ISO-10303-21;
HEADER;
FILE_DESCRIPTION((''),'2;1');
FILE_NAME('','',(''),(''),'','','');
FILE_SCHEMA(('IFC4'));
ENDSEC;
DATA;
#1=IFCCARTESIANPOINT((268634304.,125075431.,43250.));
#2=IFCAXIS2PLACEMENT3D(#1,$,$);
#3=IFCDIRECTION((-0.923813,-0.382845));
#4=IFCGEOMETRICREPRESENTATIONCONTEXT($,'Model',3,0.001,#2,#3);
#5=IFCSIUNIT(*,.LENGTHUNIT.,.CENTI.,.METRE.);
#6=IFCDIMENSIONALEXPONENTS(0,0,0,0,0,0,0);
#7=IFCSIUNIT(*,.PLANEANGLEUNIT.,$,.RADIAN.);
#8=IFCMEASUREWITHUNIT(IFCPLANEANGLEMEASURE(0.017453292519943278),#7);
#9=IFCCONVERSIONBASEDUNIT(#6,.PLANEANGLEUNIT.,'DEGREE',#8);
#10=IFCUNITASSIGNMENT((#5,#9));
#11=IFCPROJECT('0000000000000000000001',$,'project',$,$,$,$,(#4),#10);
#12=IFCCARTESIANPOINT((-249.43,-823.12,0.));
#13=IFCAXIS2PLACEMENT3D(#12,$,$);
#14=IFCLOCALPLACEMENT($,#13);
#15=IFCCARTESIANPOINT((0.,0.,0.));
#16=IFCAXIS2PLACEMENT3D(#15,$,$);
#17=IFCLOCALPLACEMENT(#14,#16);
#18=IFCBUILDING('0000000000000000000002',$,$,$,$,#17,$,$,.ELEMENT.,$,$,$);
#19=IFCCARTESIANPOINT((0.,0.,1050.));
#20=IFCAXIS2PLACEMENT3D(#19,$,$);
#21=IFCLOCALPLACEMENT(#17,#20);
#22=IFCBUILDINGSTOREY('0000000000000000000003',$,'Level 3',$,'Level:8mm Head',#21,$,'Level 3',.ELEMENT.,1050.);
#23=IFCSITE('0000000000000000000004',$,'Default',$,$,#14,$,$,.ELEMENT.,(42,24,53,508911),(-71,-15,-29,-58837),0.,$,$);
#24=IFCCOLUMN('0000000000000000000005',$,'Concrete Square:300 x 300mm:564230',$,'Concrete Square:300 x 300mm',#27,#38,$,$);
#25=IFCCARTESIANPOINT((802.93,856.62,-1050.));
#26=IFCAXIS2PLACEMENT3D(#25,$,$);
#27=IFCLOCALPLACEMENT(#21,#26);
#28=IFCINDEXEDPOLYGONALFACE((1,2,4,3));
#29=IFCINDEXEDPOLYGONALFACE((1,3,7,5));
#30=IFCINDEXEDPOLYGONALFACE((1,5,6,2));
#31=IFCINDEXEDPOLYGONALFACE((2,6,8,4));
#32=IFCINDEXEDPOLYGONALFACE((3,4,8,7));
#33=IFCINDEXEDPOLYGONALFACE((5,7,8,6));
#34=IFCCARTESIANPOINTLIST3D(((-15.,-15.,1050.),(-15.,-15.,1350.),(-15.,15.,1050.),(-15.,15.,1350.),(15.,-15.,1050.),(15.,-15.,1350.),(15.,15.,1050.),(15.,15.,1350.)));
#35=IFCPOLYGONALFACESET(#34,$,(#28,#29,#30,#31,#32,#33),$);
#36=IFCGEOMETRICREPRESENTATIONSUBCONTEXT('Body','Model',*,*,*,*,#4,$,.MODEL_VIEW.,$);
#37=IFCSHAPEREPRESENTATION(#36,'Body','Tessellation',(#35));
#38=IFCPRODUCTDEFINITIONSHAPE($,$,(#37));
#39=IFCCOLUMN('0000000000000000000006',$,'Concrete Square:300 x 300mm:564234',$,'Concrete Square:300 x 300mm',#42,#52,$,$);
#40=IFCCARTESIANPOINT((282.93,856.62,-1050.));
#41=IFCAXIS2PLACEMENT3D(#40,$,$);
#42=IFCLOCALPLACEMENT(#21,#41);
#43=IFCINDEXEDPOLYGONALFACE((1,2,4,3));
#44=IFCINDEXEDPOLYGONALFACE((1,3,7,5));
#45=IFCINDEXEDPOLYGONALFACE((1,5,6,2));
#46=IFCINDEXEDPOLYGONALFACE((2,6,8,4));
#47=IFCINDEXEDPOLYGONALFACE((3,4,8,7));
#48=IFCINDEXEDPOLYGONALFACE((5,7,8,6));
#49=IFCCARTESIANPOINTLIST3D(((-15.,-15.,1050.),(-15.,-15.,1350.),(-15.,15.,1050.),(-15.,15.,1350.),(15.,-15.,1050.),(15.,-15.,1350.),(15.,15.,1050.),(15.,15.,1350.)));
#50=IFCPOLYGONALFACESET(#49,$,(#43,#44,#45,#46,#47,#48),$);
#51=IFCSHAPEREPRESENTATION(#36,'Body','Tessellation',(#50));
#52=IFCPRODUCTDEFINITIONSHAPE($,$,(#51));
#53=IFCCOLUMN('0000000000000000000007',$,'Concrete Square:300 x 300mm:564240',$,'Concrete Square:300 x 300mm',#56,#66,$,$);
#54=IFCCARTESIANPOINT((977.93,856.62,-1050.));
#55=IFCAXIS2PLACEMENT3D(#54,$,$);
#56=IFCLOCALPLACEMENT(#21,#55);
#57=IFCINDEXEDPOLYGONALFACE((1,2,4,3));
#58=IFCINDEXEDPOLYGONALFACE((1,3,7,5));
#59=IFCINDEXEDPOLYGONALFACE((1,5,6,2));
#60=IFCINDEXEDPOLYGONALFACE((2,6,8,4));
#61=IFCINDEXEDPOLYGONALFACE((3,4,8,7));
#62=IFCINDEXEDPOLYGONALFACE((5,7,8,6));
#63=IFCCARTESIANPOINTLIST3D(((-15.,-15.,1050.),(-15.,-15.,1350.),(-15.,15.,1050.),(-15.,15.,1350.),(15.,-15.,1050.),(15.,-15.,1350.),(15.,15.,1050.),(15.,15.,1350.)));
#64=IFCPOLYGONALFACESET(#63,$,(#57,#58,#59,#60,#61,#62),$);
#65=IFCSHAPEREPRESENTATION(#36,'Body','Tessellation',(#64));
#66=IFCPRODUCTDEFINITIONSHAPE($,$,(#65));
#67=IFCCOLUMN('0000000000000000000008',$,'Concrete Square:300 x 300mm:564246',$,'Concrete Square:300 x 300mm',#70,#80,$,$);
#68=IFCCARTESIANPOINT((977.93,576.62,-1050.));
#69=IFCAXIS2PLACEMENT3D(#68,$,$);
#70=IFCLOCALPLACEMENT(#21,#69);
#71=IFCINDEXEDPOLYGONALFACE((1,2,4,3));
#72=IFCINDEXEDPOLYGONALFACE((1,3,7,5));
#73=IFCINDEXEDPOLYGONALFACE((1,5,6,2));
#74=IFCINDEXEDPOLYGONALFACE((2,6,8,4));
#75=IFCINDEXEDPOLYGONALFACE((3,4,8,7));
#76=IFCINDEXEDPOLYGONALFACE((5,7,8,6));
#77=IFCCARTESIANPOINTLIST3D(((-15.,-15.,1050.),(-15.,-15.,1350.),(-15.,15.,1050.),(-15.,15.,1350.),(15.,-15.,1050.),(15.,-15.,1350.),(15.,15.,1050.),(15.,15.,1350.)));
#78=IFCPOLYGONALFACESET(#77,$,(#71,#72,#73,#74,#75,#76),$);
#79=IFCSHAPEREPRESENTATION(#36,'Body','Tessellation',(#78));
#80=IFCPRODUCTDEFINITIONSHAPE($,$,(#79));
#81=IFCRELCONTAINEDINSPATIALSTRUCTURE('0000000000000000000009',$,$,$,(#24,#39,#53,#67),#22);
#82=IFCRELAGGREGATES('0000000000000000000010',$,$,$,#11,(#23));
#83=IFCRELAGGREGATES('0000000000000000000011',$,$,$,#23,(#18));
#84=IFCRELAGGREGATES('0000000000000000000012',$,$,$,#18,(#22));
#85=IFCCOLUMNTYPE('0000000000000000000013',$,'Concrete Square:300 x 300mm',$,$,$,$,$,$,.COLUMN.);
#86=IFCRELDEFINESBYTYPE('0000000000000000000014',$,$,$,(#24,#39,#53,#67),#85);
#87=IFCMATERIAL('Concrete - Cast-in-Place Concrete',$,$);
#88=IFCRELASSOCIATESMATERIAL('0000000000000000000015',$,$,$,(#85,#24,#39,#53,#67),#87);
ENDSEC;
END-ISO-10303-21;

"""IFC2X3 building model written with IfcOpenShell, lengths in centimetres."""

from ifc_helpers import new_model, entity, si_unit, converted_unit, direction, frame, origin, origin_2d_with_axis, place, context, subcontext, project, spatial, rectangle, extrude, source, transform, mapped, material, type_object, type_shapes, element, save


model = new_model("IFC2X3")

# Units and contexts
model_context = context("Model", 3, precision=0.001, world=frame((268634304.0, 125075431.0, 43250.0)), true_north=direction((-0.923813, -0.382845)))
body_context = subcontext(model_context, "Body", "Model", "MODEL_VIEW")
ifc_project = project(units=[si_unit("LENGTHUNIT", "METRE", prefix="CENTI"), converted_unit("PLANEANGLEUNIT", "DEGREE", entity("IfcPlaneAngleMeasure", 0.017453292519943278), si_unit("PLANEANGLEUNIT", "RADIAN"), dimensions=[0, 0, 0, 0, 0, 0, 0])], contexts=[model_context])

# Site, building, storey
site_placement = place(None, frame((-249.43, -823.12, 0.0)))
site = spatial("IfcSite", under=ifc_project, at=site_placement, Name="Default", CompositionType="ELEMENT", RefLatitude=(42, 24, 53, 508911), RefLongitude=(-71, -15, -29, -58837), RefElevation=0.0)
building_placement = place(site_placement, origin())
building = spatial("IfcBuilding", under=site, at=building_placement, CompositionType="ELEMENT")
storey_placement = place(building_placement, frame((0.0, 0.0, 1050.0)))
storey = spatial("IfcBuildingStorey", under=building, at=storey_placement, Name="Level 3", ObjectType="Level:8mm Head", LongName="Level 3", CompositionType="ELEMENT", Elevation=1050.0)

# Columns
ifc_material_1 = material(Name="Concrete - Cast-in-Place Concrete")
column_type_1 = type_object("IfcColumnType", Name="Concrete Square:300 x 300mm", PredefinedType="COLUMN", material=ifc_material_1)
shared_shape_1 = source(origin(), body_context, "Body", "SweptSolid", [
    extrude(rectangle(XDim=30.0, YDim=30.0, at=origin_2d_with_axis()), frame((0.0, 0.0, 1050.0), z_axis=(0.0, 0.0, 1.0), x_axis=(-1.0, 0.0, 0.0)), (0.0, 0.0, 1.0), 300.0),
])
type_shapes(column_type_1, [shared_shape_1])
for number, where, name in (
    (1, (802.93, 856.62, -1050.0), "Concrete Square:300 x 300mm:564230"),
    (2, (282.93, 856.62, -1050.0), "Concrete Square:300 x 300mm:564234"),
    (3, (977.93, 856.62, -1050.0), "Concrete Square:300 x 300mm:564240"),
    (4, (977.93, 576.62, -1050.0), "Concrete Square:300 x 300mm:564246"),
):
    element("IfcColumn", number, at=place(storey_placement, frame(where)), inside=storey, type_object=column_type_1, material=ifc_material_1, Name=name, ObjectType="Concrete Square:300 x 300mm", context=body_context, shape_type="MappedRepresentation", body=[
        mapped(shared_shape_1, transform((0.0, 0.0, 0.0), scale=1.0)),
    ])

save(model, "model.ifc")
